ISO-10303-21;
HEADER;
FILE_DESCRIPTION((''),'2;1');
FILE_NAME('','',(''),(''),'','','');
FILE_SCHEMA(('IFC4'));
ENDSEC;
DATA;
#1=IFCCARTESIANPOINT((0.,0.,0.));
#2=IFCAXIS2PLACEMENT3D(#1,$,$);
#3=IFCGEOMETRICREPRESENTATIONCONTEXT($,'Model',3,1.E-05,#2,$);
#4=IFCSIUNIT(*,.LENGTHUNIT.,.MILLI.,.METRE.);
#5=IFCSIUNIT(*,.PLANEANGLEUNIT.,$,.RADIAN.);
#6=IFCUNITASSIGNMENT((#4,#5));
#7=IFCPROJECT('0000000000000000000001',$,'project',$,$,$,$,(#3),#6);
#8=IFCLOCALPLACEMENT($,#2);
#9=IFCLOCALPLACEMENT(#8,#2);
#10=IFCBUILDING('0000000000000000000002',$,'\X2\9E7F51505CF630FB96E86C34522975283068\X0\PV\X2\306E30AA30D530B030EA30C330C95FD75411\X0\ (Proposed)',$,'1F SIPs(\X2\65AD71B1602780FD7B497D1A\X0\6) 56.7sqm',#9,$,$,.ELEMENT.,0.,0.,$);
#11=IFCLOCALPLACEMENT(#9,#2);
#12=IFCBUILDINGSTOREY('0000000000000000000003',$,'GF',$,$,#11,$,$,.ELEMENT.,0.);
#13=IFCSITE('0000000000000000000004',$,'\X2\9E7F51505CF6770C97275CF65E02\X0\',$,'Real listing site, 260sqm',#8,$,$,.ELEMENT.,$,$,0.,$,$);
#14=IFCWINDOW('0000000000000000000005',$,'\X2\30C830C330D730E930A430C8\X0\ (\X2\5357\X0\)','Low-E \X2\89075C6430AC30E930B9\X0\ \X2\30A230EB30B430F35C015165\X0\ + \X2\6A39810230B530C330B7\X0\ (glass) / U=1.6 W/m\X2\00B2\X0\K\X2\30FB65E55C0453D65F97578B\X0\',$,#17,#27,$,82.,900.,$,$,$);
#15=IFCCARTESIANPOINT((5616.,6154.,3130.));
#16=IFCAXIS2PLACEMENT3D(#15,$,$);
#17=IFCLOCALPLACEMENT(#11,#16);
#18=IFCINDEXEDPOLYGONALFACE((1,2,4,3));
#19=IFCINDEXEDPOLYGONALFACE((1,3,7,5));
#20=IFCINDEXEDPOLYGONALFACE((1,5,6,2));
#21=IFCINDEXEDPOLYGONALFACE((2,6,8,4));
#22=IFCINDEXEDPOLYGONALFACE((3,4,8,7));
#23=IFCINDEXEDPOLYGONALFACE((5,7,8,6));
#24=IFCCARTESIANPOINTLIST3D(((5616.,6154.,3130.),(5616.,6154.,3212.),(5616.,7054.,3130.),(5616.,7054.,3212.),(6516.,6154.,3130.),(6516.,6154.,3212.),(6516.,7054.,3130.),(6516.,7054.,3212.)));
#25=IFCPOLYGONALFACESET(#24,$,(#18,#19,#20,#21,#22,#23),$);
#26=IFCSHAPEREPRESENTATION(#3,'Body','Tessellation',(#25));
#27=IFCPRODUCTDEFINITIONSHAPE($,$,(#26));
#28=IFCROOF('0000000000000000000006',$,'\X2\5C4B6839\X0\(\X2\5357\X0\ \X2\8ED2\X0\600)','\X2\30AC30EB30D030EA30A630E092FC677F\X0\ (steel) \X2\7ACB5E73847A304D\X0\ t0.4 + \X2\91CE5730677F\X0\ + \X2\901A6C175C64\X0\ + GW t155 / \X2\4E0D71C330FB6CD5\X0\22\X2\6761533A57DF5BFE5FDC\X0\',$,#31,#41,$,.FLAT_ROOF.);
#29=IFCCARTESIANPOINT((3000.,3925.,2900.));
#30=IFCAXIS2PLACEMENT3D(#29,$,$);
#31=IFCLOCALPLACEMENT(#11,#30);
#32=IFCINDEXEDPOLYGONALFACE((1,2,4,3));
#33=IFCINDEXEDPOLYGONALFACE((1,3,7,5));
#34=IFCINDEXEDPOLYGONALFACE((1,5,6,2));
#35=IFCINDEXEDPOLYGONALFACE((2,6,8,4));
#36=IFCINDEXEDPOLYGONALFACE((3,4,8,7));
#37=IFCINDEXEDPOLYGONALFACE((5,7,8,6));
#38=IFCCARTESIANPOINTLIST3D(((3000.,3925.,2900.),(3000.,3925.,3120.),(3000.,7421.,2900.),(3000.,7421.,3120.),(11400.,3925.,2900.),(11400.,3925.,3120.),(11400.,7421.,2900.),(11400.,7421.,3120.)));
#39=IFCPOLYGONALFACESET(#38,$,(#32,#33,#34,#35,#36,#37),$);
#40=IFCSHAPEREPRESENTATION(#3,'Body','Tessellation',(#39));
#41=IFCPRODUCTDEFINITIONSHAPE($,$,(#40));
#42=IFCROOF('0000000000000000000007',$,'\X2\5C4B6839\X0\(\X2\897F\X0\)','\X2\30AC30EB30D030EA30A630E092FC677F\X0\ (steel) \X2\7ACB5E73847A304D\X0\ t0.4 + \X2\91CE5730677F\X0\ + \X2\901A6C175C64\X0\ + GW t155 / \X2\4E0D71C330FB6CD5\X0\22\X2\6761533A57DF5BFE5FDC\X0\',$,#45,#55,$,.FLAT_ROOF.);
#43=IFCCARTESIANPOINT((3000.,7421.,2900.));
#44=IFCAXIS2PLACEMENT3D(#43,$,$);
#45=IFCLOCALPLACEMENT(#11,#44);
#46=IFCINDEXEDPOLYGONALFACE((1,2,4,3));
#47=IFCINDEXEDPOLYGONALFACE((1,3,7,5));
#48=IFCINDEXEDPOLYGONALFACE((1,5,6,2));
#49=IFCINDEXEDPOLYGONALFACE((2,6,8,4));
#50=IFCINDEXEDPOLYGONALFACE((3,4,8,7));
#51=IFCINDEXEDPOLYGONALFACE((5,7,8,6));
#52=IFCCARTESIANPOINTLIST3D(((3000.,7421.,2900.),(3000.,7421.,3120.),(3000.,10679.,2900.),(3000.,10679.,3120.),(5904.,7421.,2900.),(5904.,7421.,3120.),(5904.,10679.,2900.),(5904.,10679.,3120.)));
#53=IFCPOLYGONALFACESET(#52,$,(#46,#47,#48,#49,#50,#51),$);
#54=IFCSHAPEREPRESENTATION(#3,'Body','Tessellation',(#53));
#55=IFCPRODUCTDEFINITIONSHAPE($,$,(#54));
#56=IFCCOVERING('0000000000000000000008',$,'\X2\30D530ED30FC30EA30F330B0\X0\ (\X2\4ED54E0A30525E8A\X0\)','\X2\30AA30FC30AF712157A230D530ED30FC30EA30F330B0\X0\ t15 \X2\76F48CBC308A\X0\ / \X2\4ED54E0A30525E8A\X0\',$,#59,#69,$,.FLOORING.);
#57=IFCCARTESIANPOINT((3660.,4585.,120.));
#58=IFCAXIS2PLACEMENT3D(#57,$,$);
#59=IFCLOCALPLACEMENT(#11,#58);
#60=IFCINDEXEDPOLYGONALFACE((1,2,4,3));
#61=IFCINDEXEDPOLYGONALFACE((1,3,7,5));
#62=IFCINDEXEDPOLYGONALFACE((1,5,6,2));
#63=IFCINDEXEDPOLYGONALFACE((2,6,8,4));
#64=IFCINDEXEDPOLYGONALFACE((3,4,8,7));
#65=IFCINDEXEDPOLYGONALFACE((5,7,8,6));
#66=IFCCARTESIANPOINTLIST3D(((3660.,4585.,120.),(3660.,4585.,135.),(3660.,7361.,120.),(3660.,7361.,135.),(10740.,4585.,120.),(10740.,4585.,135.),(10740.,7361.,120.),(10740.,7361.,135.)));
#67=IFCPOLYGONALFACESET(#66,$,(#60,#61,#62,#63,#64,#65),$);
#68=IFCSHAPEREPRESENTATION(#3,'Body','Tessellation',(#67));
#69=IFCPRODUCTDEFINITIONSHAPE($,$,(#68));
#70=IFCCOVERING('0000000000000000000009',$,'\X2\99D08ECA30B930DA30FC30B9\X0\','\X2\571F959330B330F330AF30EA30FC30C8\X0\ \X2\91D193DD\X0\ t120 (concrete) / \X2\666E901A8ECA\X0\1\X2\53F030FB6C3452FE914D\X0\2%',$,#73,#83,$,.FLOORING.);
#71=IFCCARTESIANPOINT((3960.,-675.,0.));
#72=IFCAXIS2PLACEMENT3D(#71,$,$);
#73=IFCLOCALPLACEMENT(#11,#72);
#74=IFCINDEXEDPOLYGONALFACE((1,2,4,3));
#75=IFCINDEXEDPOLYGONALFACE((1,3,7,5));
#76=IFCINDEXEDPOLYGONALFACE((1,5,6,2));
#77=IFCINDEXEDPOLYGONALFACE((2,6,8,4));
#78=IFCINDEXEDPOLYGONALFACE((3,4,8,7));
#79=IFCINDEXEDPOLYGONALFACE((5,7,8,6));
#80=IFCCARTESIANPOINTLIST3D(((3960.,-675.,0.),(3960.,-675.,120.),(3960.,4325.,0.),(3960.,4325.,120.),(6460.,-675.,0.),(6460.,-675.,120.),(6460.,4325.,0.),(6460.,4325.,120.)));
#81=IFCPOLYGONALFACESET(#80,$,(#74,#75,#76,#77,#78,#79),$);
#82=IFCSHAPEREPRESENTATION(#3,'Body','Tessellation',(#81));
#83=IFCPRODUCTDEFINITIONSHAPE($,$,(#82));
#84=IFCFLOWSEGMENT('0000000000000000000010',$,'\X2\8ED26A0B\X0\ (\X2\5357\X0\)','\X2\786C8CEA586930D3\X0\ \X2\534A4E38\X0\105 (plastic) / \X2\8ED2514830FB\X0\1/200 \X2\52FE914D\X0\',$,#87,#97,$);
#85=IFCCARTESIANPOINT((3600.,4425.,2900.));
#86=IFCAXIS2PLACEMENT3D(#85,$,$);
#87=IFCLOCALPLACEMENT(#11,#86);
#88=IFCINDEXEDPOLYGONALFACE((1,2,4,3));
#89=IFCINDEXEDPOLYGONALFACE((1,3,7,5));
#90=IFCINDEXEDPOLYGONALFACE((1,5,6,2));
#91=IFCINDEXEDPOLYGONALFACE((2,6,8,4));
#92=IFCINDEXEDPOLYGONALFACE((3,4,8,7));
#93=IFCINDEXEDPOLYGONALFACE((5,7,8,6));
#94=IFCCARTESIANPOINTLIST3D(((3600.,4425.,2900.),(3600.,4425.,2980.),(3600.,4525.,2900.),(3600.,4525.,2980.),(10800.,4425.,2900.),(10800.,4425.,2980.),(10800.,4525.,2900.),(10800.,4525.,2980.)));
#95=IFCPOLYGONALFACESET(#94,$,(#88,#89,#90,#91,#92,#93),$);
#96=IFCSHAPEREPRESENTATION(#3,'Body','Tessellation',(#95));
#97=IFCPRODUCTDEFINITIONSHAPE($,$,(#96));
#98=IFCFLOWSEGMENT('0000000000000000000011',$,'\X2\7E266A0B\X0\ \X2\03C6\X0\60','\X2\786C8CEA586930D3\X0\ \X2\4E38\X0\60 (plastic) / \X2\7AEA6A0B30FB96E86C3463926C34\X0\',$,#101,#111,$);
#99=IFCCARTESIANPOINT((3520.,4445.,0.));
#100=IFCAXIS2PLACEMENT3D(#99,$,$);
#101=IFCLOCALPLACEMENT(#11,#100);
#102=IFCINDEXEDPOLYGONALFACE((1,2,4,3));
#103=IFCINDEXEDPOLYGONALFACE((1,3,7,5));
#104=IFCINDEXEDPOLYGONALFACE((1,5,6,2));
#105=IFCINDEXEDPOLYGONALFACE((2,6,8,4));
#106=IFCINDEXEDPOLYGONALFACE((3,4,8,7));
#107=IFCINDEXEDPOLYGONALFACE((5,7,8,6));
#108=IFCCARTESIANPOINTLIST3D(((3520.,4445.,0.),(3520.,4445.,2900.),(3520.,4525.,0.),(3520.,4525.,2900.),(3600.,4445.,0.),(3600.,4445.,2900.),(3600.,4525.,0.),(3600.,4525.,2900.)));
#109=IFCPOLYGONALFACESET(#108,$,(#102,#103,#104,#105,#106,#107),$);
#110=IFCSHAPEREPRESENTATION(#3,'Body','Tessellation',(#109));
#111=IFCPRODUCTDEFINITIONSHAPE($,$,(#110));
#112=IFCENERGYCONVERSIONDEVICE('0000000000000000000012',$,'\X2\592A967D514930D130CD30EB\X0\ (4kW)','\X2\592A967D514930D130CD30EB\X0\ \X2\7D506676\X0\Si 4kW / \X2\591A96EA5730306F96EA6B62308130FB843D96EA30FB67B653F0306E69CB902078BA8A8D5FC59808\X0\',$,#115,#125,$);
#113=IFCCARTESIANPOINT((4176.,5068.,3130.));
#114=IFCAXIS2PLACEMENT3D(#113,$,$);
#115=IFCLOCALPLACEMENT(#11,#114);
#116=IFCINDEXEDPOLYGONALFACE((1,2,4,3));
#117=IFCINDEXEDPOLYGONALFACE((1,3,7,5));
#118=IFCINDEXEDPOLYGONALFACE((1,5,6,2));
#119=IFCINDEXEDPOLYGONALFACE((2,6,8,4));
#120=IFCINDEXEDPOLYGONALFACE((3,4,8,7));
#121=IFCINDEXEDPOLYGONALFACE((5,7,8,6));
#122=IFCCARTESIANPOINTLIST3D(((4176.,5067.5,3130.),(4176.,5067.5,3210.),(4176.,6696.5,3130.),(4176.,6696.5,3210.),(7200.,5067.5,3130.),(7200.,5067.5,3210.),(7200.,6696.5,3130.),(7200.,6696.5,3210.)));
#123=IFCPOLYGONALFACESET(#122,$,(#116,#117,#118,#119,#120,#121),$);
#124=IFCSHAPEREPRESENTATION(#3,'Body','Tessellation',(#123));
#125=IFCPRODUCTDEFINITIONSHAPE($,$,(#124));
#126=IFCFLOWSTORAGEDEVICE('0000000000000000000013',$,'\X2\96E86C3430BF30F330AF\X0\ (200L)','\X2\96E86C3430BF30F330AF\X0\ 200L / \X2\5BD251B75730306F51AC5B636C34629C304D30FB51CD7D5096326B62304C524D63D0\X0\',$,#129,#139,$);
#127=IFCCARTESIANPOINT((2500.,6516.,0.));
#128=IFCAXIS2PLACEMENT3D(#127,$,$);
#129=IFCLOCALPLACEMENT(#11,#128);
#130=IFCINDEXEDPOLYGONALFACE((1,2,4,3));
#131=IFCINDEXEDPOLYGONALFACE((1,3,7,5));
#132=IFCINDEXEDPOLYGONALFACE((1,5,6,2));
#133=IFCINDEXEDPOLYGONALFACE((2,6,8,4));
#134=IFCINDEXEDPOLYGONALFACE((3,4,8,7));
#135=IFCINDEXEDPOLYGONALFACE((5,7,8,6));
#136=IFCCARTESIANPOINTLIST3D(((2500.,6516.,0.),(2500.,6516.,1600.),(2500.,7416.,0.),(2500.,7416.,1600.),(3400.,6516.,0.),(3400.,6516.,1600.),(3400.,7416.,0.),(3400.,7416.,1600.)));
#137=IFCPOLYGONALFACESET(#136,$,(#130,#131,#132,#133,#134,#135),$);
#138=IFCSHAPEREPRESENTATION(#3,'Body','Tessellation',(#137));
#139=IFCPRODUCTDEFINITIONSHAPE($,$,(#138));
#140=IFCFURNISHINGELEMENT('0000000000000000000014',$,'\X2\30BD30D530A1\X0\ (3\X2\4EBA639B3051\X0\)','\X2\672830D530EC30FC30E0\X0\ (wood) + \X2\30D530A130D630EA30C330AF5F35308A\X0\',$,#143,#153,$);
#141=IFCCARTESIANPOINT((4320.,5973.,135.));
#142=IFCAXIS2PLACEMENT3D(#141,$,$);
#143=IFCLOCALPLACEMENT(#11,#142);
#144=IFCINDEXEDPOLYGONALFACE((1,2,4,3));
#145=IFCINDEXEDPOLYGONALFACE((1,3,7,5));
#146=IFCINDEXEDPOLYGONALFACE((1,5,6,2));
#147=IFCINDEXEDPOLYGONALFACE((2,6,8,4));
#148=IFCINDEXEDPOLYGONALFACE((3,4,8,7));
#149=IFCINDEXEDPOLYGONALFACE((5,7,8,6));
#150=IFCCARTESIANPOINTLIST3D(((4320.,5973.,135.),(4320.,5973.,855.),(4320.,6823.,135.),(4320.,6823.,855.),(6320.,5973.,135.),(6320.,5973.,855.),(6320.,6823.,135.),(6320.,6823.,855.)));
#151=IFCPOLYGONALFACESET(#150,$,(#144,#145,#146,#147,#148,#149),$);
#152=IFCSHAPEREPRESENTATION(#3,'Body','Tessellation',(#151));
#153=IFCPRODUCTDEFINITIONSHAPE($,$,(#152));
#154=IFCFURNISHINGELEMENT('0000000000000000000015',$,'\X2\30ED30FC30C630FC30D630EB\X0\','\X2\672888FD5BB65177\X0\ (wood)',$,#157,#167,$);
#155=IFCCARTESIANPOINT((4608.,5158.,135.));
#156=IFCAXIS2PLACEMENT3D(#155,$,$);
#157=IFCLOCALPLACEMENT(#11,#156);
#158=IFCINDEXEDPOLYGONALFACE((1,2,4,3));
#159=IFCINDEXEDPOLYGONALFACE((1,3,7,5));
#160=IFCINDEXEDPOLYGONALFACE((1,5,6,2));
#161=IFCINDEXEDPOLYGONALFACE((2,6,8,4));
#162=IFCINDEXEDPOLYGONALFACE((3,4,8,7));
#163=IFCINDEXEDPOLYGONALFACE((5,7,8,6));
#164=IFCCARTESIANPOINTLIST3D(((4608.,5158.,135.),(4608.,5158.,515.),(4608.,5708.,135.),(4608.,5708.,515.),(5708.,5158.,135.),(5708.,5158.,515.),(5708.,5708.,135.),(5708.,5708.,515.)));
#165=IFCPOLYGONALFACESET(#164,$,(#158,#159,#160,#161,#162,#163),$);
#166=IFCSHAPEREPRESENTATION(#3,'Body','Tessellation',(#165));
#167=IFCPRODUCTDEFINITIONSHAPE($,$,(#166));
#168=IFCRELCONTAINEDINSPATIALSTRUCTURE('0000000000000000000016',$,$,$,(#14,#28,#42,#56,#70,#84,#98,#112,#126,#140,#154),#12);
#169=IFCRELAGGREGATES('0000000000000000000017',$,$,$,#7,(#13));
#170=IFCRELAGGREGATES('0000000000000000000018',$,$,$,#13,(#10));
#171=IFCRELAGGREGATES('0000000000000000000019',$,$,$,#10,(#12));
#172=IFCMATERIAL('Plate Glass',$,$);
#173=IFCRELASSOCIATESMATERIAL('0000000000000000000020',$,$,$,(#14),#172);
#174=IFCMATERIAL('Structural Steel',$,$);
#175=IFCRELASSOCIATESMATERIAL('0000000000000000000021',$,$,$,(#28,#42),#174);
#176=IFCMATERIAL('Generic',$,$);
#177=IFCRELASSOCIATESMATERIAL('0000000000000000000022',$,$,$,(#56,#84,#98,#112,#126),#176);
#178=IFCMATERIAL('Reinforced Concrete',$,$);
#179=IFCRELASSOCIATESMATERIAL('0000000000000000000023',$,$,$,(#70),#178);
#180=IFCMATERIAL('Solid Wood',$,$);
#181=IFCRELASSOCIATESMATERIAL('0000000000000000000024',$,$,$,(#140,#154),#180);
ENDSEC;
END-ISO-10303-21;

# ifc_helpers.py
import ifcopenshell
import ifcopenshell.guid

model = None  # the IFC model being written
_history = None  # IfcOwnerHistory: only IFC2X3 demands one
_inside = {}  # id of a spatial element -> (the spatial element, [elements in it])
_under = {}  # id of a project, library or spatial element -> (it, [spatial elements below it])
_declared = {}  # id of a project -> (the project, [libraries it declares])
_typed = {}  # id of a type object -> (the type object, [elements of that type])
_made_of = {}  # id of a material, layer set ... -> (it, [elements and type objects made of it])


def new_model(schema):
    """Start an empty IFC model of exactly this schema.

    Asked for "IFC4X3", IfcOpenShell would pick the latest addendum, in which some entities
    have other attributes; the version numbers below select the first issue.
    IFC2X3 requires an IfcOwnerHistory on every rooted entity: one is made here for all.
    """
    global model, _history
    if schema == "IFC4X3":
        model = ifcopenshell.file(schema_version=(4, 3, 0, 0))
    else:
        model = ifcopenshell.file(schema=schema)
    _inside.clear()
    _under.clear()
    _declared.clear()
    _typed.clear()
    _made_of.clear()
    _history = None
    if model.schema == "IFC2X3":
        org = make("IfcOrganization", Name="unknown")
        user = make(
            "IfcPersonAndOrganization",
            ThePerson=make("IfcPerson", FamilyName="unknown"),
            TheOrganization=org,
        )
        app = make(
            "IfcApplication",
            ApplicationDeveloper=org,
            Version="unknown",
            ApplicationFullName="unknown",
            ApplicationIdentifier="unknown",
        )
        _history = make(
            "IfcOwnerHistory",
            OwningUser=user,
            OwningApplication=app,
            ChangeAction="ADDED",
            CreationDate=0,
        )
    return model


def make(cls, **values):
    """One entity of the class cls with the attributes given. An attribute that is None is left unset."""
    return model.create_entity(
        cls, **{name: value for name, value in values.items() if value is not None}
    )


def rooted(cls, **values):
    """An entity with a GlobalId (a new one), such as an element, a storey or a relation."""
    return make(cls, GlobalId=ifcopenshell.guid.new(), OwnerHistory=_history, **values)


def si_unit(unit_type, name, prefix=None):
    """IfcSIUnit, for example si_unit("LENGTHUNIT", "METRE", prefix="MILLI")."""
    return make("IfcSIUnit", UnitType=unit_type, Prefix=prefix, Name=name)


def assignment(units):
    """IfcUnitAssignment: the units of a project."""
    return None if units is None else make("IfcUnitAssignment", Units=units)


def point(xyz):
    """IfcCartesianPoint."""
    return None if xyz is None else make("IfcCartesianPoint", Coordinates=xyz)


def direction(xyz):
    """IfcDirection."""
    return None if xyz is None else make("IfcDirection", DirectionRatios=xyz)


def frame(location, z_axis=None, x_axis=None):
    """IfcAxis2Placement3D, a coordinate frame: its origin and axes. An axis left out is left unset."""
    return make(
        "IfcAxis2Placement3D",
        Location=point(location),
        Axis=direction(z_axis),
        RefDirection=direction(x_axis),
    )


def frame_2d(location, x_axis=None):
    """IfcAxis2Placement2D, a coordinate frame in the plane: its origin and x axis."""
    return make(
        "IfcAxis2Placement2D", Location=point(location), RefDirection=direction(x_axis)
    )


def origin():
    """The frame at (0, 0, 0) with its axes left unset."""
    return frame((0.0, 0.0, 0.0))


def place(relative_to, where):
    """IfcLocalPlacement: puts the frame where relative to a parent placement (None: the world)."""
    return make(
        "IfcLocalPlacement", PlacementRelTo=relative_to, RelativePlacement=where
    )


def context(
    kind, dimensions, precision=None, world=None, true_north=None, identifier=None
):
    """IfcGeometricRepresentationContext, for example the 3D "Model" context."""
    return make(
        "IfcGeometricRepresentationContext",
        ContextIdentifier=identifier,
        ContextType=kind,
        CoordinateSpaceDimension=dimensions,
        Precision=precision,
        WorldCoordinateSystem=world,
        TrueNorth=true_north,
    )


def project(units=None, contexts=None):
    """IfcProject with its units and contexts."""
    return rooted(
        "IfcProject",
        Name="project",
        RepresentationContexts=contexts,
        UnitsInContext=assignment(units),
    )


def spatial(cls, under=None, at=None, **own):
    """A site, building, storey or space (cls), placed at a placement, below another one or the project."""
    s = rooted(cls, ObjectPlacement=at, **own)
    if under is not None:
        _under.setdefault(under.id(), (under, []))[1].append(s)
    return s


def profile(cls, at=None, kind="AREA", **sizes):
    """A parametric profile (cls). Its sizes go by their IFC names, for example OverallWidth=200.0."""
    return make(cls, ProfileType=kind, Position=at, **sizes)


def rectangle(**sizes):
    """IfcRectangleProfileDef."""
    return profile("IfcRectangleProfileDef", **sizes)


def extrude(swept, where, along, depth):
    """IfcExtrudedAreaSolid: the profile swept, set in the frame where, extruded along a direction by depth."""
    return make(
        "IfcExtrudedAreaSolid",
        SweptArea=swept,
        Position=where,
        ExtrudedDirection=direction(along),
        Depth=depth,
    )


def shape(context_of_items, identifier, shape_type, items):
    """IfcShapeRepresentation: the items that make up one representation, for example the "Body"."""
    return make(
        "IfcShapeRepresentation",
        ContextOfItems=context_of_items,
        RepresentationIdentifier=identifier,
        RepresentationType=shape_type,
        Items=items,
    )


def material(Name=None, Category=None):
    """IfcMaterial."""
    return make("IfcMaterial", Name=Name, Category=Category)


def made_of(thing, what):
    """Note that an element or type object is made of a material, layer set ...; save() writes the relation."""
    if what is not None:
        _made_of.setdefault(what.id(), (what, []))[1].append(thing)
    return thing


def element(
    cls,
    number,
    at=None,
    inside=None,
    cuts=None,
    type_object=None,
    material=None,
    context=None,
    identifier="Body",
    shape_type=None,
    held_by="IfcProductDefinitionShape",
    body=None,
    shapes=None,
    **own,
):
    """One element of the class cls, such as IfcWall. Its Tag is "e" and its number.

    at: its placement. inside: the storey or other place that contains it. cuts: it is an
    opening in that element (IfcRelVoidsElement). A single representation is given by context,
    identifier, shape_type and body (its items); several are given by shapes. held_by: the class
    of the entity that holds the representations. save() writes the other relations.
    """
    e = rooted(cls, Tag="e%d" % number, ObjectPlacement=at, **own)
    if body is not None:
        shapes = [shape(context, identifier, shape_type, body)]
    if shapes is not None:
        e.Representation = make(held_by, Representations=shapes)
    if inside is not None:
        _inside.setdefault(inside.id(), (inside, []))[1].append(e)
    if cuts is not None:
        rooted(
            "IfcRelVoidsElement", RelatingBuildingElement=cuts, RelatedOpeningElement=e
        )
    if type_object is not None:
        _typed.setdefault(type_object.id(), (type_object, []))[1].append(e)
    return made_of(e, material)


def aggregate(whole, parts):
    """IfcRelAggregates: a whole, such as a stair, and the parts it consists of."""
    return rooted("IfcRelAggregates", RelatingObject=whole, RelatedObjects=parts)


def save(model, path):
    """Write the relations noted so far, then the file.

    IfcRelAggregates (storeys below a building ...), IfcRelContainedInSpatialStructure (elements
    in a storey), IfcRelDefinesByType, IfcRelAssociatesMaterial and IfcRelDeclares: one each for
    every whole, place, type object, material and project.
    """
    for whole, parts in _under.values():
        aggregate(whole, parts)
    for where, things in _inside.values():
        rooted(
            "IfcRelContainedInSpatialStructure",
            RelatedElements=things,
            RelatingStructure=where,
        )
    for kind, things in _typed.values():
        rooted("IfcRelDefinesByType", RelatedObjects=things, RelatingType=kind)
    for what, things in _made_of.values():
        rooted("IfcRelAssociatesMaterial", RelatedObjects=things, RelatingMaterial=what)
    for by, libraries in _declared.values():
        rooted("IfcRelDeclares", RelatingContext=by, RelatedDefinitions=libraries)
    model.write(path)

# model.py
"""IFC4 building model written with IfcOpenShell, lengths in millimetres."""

from ifc_helpers import new_model, si_unit, frame, frame_2d, origin, place, context, project, spatial, rectangle, extrude, material, element, save


model = new_model("IFC4")

# Units and contexts
model_context = context("Model", 3, precision=1e-05, world=origin())
ifc_project = project(units=[si_unit("LENGTHUNIT", "METRE", prefix="MILLI"), si_unit("PLANEANGLEUNIT", "RADIAN")], contexts=[model_context])

# Site, building, storey
site_placement = place(None, origin())
site = spatial("IfcSite", under=ifc_project, at=site_placement, Name="鹿児島県霧島市", ObjectType="Real listing site, 260sqm", CompositionType="ELEMENT", RefElevation=0.0)
building_placement = place(site_placement, origin())
building = spatial("IfcBuilding", under=site, at=building_placement, Name="鹿児島・雨水利用とPVのオフグリッド志向 (Proposed)", ObjectType="1F SIPs(断熱性能等級6) 56.7sqm", CompositionType="ELEMENT", ElevationOfRefHeight=0.0, ElevationOfTerrain=0.0)
storey_placement = place(building_placement, origin())
storey = spatial("IfcBuildingStorey", under=building, at=storey_placement, Name="GF", CompositionType="ELEMENT", Elevation=0.0)

# Shared definitions
ifc_material_1 = material(Name="Solid Wood")

# Shared definitions
ifc_material_2 = material(Name="Reinforced Concrete")

# Shared definitions
ifc_material_3 = material(Name="Plate Glass")

# Window
window_1_placement = place(storey_placement, frame((5616.0, 6154.0, 3130.0)))
element("IfcWindow", 1, at=window_1_placement, inside=storey, material=ifc_material_3, Name="トップライト (南)", Description="Low-E 複層ガラス アルゴン封入 + 樹脂サッシ (glass) / U=1.6 W/m²K・日射取得型", OverallHeight=82.0, OverallWidth=900.0, context=model_context, shape_type="SweptSolid", body=[
    extrude(rectangle(XDim=900.0, YDim=900.0, at=frame_2d((450.0, 450.0))), frame((5616.0, 6154.0, 3130.0)), (0.0, 0.0, 1.0), 82.0),
])

# Roofs
ifc_material_4 = material(Name="Structural Steel")
roof_1_placement = place(storey_placement, frame((3000.0, 3925.0, 2900.0)))
element("IfcRoof", 2, at=roof_1_placement, inside=storey, material=ifc_material_4, Name="屋根(南 軒600)", Description="ガルバリウム鋼板 (steel) 立平葺き t0.4 + 野地板 + 通気層 + GW t155 / 不燃・法22条区域対応", PredefinedType="FLAT_ROOF", context=model_context, shape_type="SweptSolid", body=[
    extrude(rectangle(XDim=8400.0, YDim=3496.0, at=frame_2d((4200.0, 1748.0))), frame((3000.0, 3925.0, 2900.0)), (0.0, 0.0, 1.0), 220.0),
])
roof_2_placement = place(storey_placement, frame((3000.0, 7421.0, 2900.0)))
element("IfcRoof", 3, at=roof_2_placement, inside=storey, material=ifc_material_4, Name="屋根(西)", Description="ガルバリウム鋼板 (steel) 立平葺き t0.4 + 野地板 + 通気層 + GW t155 / 不燃・法22条区域対応", PredefinedType="FLAT_ROOF", context=model_context, shape_type="SweptSolid", body=[
    extrude(rectangle(XDim=2904.0, YDim=3258.0, at=frame_2d((1452.0, 1629.0))), frame((3000.0, 7421.0, 2900.0)), (0.0, 0.0, 1.0), 220.0),
])

# Coverings
ifc_material_5 = material(Name="Generic")
covering_1_placement = place(storey_placement, frame((3660.0, 4585.0, 120.0)))
element("IfcCovering", 4, at=covering_1_placement, inside=storey, material=ifc_material_5, Name="フローリング (仕上げ床)", Description="オーク無垢フローリング t15 直貼り / 仕上げ床", PredefinedType="FLOORING", context=model_context, shape_type="SweptSolid", body=[
    extrude(rectangle(XDim=7080.0, YDim=2776.0, at=frame_2d((3540.0, 1388.0))), frame((3660.0, 4585.0, 120.0)), (0.0, 0.0, 1.0), 15.0),
])
covering_2_placement = place(storey_placement, frame((3960.0, -675.0, 0.0)))
element("IfcCovering", 5, at=covering_2_placement, inside=storey, material=ifc_material_2, Name="駐車スペース", Description="土間コンクリート 金鏝 t120 (concrete) / 普通車1台・水勾配2%", PredefinedType="FLOORING", context=model_context, shape_type="SweptSolid", body=[
    extrude(rectangle(XDim=2500.0, YDim=5000.0, at=frame_2d((1250.0, 2500.0))), frame((3960.0, -675.0, 0.0)), (0.0, 0.0, 1.0), 120.0),
])

# Flow segments
flow_segment_1_placement = place(storey_placement, frame((3600.0, 4425.0, 2900.0)))
element("IfcFlowSegment", 6, at=flow_segment_1_placement, inside=storey, material=ifc_material_5, Name="軒樋 (南)", Description="硬質塩ビ 半丸105 (plastic) / 軒先・1/200 勾配", context=model_context, shape_type="SweptSolid", body=[
    extrude(rectangle(XDim=7200.0, YDim=100.0, at=frame_2d((3600.0, 50.0))), frame((3600.0, 4425.0, 2900.0)), (0.0, 0.0, 1.0), 80.0),
])
flow_segment_2_placement = place(storey_placement, frame((3520.0, 4445.0, 0.0)))
element("IfcFlowSegment", 7, at=flow_segment_2_placement, inside=storey, material=ifc_material_5, Name="縦樋 φ60", Description="硬質塩ビ 丸60 (plastic) / 竪樋・雨水排水", context=model_context, shape_type="SweptSolid", body=[
    extrude(rectangle(XDim=80.0, YDim=80.0, at=frame_2d((40.0, 40.0))), frame((3520.0, 4445.0, 0.0)), (0.0, 0.0, 1.0), 2900.0),
])

# Energy conversion device
energy_conversion_device_placement = place(storey_placement, frame((4176.0, 5068.0, 3130.0)))
element("IfcEnergyConversionDevice", 8, at=energy_conversion_device_placement, inside=storey, material=ifc_material_5, Name="太陽光パネル (4kW)", Description="太陽光パネル 結晶Si 4kW / 多雪地は雪止め・落雪・架台の構造確認必須", context=model_context, shape_type="SweptSolid", body=[
    extrude(rectangle(XDim=3024.0, YDim=1629.0, at=frame_2d((1512.0, 814.0))), frame((4176.0, 5068.0, 3130.0)), (0.0, 0.0, 1.0), 80.0),
])

# Flow storage device
flow_storage_device_placement = place(storey_placement, frame((2500.0, 6516.0, 0.0)))
element("IfcFlowStorageDevice", 9, at=flow_storage_device_placement, inside=storey, material=ifc_material_5, Name="雨水タンク (200L)", Description="雨水タンク 200L / 寒冷地は冬季水抜き・凍結防止が前提", context=model_context, shape_type="SweptSolid", body=[
    extrude(rectangle(XDim=900.0, YDim=900.0, at=frame_2d((450.0, 450.0))), frame((2500.0, 6516.0, 0.0)), (0.0, 0.0, 1.0), 1600.0),
])

# Furnishing elements
furnishing_1_placement = place(storey_placement, frame((4320.0, 5973.0, 135.0)))
element("IfcFurnishingElement", 10, at=furnishing_1_placement, inside=storey, material=ifc_material_1, Name="ソファ (3人掛け)", Description="木フレーム (wood) + ファブリック張り", context=model_context, shape_type="SweptSolid", body=[
    extrude(rectangle(XDim=2000.0, YDim=850.0, at=frame_2d((1000.0, 425.0))), frame((4320.0, 5973.0, 135.0)), (0.0, 0.0, 1.0), 720.0),
])
furnishing_2_placement = place(storey_placement, frame((4608.0, 5158.0, 135.0)))
element("IfcFurnishingElement", 11, at=furnishing_2_placement, inside=storey, material=ifc_material_1, Name="ローテーブル", Description="木製家具 (wood)", context=model_context, shape_type="SweptSolid", body=[
    extrude(rectangle(XDim=1100.0, YDim=550.0, at=frame_2d((550.0, 275.0))), frame((4608.0, 5158.0, 135.0)), (0.0, 0.0, 1.0), 380.0),
])

save(model, "model.ifc")
